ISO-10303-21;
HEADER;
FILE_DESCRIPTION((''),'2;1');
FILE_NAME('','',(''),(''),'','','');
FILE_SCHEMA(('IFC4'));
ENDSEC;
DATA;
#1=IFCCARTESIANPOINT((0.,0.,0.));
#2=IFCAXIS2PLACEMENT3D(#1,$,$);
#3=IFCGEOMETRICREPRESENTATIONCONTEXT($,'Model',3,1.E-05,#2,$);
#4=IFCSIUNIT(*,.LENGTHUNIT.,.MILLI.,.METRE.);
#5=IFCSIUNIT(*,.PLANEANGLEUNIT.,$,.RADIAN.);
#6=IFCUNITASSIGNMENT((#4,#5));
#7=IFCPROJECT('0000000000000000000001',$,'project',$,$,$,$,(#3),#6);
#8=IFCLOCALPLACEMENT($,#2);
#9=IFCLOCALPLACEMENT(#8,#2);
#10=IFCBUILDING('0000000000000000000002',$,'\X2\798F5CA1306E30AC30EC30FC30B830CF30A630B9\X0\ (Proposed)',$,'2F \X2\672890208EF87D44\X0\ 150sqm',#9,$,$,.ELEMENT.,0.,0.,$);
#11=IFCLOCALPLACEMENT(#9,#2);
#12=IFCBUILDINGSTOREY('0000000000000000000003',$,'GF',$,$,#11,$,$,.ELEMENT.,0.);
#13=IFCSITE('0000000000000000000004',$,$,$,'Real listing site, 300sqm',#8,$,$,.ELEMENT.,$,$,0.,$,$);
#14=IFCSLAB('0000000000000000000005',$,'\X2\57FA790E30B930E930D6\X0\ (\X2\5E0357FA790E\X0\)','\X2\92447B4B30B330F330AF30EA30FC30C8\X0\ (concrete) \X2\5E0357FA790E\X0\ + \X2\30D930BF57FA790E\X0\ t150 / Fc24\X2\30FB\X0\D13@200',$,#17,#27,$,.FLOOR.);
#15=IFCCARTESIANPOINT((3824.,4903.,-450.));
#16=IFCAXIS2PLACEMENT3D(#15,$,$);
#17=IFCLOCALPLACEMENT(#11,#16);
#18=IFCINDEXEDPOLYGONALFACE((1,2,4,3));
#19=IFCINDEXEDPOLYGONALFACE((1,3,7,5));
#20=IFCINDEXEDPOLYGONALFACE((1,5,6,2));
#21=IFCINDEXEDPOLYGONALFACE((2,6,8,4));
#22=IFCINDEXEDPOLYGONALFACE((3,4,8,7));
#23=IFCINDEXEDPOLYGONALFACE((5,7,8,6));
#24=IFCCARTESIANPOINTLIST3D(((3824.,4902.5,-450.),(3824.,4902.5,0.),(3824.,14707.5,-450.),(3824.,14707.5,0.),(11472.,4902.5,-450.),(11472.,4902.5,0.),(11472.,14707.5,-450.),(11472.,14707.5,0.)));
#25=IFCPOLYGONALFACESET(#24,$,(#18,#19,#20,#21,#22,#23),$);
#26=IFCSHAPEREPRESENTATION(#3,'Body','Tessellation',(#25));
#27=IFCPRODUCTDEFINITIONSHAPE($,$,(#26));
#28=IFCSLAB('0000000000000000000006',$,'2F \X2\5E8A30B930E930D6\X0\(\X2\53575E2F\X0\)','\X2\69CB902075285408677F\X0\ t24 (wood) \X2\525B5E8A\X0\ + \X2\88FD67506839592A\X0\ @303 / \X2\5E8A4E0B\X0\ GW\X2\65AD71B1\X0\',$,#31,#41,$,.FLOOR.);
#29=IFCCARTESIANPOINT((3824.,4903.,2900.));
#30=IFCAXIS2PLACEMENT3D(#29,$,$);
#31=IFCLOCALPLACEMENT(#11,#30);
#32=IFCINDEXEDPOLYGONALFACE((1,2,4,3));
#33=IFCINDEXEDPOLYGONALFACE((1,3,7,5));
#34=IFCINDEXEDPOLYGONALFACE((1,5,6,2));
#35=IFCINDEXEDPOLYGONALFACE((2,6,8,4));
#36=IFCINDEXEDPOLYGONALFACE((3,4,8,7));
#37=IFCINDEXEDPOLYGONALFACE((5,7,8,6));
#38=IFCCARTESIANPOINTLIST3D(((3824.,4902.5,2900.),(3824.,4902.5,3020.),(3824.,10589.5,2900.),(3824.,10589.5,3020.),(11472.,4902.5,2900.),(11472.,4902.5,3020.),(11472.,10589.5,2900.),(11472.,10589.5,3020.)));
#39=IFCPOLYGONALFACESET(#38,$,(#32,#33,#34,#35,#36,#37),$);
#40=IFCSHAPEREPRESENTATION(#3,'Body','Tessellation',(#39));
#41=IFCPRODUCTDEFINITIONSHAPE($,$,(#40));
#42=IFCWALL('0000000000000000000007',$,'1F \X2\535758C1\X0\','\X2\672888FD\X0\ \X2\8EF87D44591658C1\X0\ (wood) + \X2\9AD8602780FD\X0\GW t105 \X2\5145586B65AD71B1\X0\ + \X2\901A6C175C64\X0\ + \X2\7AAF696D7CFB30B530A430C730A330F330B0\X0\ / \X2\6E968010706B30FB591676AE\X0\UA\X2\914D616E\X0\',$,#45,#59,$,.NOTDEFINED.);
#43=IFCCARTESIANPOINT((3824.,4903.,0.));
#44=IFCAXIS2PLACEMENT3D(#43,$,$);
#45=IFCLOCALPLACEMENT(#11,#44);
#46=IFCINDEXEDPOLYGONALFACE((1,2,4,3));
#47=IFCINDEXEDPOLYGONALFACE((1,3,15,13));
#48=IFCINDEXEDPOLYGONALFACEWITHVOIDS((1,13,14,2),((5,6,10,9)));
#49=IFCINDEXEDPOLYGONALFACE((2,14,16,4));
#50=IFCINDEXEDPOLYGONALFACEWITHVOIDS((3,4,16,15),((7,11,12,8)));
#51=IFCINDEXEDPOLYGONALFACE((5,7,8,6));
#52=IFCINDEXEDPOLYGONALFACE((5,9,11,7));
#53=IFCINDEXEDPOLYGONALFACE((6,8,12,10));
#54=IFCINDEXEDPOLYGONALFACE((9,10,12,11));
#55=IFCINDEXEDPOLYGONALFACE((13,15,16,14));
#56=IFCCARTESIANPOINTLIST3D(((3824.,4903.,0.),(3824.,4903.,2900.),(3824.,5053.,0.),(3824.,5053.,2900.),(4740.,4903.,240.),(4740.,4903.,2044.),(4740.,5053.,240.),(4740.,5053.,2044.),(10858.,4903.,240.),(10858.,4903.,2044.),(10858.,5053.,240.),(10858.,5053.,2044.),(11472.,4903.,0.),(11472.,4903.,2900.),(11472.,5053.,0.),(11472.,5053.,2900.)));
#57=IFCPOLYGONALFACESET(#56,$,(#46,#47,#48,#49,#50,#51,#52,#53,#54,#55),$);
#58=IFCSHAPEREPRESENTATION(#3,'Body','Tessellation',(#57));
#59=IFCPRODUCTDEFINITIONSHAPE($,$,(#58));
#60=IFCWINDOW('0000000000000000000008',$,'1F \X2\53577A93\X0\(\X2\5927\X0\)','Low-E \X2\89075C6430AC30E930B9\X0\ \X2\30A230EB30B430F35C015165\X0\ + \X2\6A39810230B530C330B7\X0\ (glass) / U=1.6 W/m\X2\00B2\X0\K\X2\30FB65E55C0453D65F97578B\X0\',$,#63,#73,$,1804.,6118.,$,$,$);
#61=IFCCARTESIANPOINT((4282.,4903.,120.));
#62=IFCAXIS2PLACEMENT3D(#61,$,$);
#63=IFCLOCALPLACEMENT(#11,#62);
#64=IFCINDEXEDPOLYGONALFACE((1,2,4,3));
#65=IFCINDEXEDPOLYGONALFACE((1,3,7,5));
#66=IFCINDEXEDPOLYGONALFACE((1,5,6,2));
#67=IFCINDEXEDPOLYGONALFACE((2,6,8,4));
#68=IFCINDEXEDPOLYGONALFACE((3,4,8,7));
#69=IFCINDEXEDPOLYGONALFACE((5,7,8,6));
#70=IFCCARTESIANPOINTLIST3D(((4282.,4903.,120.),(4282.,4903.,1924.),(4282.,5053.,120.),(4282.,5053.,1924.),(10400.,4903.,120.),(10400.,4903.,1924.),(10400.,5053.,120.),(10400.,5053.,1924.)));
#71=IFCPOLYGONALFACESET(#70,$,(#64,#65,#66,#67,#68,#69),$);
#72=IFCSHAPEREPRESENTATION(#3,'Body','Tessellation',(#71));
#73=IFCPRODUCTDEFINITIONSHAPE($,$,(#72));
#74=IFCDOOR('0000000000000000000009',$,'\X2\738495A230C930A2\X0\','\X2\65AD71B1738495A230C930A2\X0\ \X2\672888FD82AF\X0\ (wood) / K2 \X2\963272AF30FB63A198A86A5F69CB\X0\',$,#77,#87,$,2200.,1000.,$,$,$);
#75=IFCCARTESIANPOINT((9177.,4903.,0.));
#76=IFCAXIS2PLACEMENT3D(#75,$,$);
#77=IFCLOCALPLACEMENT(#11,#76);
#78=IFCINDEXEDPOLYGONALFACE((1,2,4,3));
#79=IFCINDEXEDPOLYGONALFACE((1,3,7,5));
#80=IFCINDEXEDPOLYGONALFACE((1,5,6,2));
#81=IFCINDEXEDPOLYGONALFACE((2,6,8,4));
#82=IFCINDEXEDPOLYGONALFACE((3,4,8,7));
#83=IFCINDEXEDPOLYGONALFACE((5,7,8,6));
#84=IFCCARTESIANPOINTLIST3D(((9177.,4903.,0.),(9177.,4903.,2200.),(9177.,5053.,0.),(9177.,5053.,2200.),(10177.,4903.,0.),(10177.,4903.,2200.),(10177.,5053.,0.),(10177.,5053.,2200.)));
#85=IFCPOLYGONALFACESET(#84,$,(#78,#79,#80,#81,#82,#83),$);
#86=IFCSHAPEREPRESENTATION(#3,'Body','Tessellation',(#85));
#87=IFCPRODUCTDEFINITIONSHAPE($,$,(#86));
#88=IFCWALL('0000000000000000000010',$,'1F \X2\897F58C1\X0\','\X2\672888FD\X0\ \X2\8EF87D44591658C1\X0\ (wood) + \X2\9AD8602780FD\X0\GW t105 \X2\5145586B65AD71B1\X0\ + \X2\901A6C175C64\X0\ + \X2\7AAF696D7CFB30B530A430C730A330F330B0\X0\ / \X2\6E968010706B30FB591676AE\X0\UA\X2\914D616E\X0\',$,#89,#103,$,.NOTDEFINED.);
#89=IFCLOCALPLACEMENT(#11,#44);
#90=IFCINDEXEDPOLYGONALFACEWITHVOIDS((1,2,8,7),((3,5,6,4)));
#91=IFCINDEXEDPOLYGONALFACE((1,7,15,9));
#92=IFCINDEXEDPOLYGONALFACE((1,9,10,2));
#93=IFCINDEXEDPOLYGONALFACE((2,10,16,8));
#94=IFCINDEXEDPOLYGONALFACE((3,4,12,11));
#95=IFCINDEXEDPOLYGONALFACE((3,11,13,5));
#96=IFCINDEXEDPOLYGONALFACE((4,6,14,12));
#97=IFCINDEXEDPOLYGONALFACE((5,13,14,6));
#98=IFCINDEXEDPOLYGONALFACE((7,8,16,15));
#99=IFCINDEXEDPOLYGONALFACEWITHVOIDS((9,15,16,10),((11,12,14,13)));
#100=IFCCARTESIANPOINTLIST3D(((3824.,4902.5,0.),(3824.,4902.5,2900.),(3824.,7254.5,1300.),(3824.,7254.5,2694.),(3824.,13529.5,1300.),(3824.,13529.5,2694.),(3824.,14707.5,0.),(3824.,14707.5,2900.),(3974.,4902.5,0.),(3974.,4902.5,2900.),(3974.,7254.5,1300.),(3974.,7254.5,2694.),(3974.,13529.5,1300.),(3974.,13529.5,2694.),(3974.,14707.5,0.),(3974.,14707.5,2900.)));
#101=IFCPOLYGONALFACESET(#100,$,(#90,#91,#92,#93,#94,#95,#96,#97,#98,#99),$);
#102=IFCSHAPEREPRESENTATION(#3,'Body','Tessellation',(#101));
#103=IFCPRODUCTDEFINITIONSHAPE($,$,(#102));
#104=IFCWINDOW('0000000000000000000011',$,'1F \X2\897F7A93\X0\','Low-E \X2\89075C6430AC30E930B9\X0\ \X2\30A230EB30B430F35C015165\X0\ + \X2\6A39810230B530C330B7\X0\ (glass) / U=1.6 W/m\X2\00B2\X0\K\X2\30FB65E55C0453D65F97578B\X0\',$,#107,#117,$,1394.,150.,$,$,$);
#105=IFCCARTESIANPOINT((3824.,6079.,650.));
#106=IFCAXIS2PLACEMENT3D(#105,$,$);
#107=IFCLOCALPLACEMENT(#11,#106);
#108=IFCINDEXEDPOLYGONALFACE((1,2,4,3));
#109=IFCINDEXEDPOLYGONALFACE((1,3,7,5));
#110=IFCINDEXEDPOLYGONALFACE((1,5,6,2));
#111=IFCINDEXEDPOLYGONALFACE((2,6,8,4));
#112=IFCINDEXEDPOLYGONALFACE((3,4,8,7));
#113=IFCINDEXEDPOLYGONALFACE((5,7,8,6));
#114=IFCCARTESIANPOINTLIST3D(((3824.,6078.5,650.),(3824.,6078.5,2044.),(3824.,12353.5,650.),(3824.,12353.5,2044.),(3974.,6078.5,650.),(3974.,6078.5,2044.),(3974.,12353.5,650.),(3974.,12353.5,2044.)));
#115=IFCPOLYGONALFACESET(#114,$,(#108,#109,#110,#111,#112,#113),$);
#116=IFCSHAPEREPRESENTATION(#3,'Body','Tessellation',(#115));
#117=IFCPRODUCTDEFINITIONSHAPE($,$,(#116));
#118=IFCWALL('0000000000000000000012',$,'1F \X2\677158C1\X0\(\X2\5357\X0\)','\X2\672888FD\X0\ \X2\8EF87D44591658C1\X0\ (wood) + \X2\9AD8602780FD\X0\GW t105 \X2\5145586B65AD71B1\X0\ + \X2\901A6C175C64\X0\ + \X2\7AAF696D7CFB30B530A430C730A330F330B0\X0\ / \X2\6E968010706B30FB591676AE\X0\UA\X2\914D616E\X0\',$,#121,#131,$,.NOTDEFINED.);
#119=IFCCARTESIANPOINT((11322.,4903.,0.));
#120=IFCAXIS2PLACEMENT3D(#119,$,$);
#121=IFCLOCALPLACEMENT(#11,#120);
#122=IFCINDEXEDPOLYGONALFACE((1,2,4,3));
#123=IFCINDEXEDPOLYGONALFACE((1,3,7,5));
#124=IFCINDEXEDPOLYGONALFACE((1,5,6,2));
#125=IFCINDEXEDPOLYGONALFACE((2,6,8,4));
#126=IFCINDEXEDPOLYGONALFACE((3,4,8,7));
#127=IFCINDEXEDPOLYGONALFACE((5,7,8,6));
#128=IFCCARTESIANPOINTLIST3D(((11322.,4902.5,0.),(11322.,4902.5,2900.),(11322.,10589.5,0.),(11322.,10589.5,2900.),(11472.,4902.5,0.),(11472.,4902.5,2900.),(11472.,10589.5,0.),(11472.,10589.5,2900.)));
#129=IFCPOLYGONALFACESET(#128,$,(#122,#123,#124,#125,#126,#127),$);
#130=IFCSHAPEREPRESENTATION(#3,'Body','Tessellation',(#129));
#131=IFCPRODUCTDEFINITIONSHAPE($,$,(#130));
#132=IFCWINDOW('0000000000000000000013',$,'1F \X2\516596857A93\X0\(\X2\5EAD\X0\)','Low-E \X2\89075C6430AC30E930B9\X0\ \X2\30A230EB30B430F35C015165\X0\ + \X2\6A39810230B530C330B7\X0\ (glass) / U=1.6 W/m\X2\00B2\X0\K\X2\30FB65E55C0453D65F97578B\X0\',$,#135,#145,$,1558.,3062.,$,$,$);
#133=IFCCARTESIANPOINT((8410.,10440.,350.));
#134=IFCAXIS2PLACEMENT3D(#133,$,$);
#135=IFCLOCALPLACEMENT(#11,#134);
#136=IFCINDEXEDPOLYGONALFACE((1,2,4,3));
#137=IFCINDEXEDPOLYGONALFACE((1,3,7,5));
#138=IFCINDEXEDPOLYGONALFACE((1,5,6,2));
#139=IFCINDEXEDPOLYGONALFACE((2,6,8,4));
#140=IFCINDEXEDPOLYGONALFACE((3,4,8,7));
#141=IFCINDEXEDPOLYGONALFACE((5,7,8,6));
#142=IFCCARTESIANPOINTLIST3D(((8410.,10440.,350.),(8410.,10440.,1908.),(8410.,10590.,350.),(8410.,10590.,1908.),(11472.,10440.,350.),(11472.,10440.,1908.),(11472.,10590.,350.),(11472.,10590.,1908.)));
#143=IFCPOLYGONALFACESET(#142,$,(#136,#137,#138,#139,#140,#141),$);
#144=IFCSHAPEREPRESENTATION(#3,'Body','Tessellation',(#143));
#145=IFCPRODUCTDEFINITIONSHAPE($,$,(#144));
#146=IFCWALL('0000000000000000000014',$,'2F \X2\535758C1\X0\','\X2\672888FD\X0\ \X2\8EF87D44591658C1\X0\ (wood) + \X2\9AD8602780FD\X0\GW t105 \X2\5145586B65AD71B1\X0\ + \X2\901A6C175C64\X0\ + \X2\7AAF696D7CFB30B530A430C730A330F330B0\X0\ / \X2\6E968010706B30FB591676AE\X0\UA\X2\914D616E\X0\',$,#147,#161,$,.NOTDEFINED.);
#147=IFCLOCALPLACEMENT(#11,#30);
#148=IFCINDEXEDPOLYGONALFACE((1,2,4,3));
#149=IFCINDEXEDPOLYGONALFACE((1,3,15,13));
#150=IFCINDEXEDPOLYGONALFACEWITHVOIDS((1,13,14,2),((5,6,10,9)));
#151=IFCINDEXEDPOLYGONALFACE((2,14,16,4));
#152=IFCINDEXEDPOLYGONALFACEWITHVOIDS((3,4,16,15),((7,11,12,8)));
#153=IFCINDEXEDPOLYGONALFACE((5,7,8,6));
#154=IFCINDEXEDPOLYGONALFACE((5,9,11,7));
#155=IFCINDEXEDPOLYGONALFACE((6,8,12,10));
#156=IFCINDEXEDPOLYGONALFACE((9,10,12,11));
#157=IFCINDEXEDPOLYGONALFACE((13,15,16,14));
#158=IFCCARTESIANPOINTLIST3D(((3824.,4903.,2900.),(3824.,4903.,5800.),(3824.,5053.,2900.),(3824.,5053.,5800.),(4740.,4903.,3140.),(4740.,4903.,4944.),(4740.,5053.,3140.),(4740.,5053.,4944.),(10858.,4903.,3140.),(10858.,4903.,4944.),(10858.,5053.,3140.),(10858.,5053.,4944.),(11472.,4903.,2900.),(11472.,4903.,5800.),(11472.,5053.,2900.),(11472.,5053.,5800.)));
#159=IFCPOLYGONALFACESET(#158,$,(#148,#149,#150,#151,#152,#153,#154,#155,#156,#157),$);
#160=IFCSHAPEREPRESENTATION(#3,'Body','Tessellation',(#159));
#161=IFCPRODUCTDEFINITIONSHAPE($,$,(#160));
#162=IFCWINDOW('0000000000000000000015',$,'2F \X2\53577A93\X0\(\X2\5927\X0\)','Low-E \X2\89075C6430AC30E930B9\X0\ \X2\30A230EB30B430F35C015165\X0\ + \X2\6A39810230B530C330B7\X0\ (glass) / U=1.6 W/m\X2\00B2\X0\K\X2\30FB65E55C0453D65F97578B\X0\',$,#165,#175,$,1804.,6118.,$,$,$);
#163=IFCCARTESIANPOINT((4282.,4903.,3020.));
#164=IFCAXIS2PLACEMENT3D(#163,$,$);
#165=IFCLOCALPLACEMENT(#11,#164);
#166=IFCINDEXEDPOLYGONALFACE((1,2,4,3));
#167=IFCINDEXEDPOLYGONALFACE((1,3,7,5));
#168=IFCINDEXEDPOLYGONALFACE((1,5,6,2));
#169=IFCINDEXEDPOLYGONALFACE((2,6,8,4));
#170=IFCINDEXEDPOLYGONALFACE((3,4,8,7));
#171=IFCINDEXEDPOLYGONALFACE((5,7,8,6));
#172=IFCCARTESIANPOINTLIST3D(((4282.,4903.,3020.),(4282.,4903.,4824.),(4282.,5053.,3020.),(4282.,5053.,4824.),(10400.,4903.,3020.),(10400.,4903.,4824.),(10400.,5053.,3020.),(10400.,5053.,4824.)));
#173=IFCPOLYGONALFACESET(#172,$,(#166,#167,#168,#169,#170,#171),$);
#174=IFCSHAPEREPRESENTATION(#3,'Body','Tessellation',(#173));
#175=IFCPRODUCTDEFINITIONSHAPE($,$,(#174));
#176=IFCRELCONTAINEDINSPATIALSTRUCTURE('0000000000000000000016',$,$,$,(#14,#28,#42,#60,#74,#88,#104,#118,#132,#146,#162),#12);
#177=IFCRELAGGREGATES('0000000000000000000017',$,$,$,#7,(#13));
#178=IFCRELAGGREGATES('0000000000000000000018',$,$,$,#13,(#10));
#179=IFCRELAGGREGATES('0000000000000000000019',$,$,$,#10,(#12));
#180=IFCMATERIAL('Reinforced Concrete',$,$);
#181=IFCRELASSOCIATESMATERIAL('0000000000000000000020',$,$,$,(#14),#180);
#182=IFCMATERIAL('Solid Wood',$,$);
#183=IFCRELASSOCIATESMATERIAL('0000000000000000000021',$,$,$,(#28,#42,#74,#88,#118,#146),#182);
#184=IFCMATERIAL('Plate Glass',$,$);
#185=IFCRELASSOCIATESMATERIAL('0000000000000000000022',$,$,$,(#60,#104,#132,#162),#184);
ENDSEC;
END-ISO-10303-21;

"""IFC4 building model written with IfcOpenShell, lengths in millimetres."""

from ifc_helpers import new_model, si_unit, frame, frame_2d, origin, place, context, project, spatial, rectangle, extrude, material, element, fill, save


model = new_model("IFC4")

# Units and contexts
model_context = context("Model", 3, precision=1e-05, world=origin())
ifc_project = project(units=[si_unit("LENGTHUNIT", "METRE", prefix="MILLI"), si_unit("PLANEANGLEUNIT", "RADIAN")], contexts=[model_context])

# Site, building, storey
site_placement = place(None, origin())
site = spatial("IfcSite", under=ifc_project, at=site_placement, ObjectType="Real listing site, 300sqm", CompositionType="ELEMENT", RefElevation=0.0)
building_placement = place(site_placement, origin())
building = spatial("IfcBuilding", under=site, at=building_placement, Name="福岡のガレージハウス (Proposed)", ObjectType="2F 木造軸組 150sqm", CompositionType="ELEMENT", ElevationOfRefHeight=0.0, ElevationOfTerrain=0.0)
storey_placement = place(building_placement, origin())
storey = spatial("IfcBuildingStorey", under=building, at=storey_placement, Name="GF", CompositionType="ELEMENT", Elevation=0.0)

# Slabs
ifc_material_1 = material(Name="Reinforced Concrete")
slab_1_placement = place(storey_placement, frame((3824.0, 4903.0, -450.0)))
element("IfcSlab", 1, at=slab_1_placement, inside=storey, material=ifc_material_1, Name="基礎スラブ (布基礎)", Description="鉄筋コンクリート (concrete) 布基礎 + ベタ基礎 t150 / Fc24・D13@200", PredefinedType="FLOOR", context=model_context, shape_type="SweptSolid", body=[
    extrude(rectangle(XDim=7648.0, YDim=9805.0, at=frame_2d((3824.0, 4902.0))), frame((3824.0, 4903.0, -450.0)), (0.0, 0.0, 1.0), 450.0),
])
ifc_material_2 = material(Name="Solid Wood")
slab_2_placement = place(storey_placement, frame((3824.0, 4903.0, 2900.0)))
element("IfcSlab", 2, at=slab_2_placement, inside=storey, material=ifc_material_2, Name="2F 床スラブ(南帯)", Description="構造用合板 t24 (wood) 剛床 + 製材根太 @303 / 床下 GW断熱", PredefinedType="FLOOR", context=model_context, shape_type="SweptSolid", body=[
    extrude(rectangle(XDim=7648.0, YDim=5687.0, at=frame_2d((3824.0, 2843.0))), frame((3824.0, 4903.0, 2900.0)), (0.0, 0.0, 1.0), 120.0),
])

# Wall, openings, window, door
wall_1_placement = place(storey_placement, frame((3824.0, 4903.0, 0.0)))
wall_1 = element("IfcWall", 3, at=wall_1_placement, inside=storey, material=ifc_material_2, Name="1F 南壁", Description="木製 軸組外壁 (wood) + 高性能GW t105 充填断熱 + 通気層 + 窯業系サイディング / 準耐火・外皮UA配慮", PredefinedType="NOTDEFINED", context=model_context, shape_type="SweptSolid", body=[
    extrude(rectangle(XDim=7648.0, YDim=150.0, at=frame_2d((3824.0, 75.0))), frame((3824.0, 4903.0, 0.0)), (0.0, 0.0, 1.0), 2900.0),
])
opening_1_placement = place(storey_placement, frame((4282.0, 4903.0, 120.0)))
opening_1 = element("IfcOpeningElement", 4, at=opening_1_placement, cuts=wall_1, PredefinedType="NOTDEFINED", context=model_context, shape_type="SweptSolid", body=[
    extrude(rectangle(XDim=6118.0, YDim=150.0, at=frame_2d((3059.0, 75.0))), frame((4282.0, 4903.0, 120.0)), (0.0, 0.0, 1.0), 1804.0),
])
opening_2_placement = place(storey_placement, frame((9177.0, 4903.0, 0.0)))
opening_2 = element("IfcOpeningElement", 5, at=opening_2_placement, cuts=wall_1, PredefinedType="NOTDEFINED", context=model_context, shape_type="SweptSolid", body=[
    extrude(rectangle(XDim=1000.0, YDim=150.0, at=frame_2d((500.0, 75.0))), frame((9177.0, 4903.0, 0.0)), (0.0, 0.0, 1.0), 2200.0),
])
ifc_material_3 = material(Name="Plate Glass")
window_1_placement = place(storey_placement, frame((4282.0, 4903.0, 120.0)))
window_1 = element("IfcWindow", 6, at=window_1_placement, inside=storey, material=ifc_material_3, Name="1F 南窓(大)", Description="Low-E 複層ガラス アルゴン封入 + 樹脂サッシ (glass) / U=1.6 W/m²K・日射取得型", OverallHeight=1804.0, OverallWidth=6118.0, context=model_context, shape_type="SweptSolid", body=[
    extrude(rectangle(XDim=6118.0, YDim=150.0, at=frame_2d((3059.0, 75.0))), frame((4282.0, 4903.0, 120.0)), (0.0, 0.0, 1.0), 1804.0),
])
fill(opening_1, window_1)
door_placement = place(storey_placement, frame((9177.0, 4903.0, 0.0)))
door = element("IfcDoor", 7, at=door_placement, inside=storey, material=ifc_material_2, Name="玄関ドア", Description="断熱玄関ドア 木製芯 (wood) / K2 防犯・採風機構", OverallHeight=2200.0, OverallWidth=1000.0, context=model_context, shape_type="SweptSolid", body=[
    extrude(rectangle(XDim=1000.0, YDim=150.0, at=frame_2d((500.0, 75.0))), frame((9177.0, 4903.0, 0.0)), (0.0, 0.0, 1.0), 2200.0),
])
fill(opening_2, door)

# Walls, openings, windows
wall_2_placement = place(storey_placement, frame((3824.0, 4903.0, 0.0)))
wall_2 = element("IfcWall", 8, at=wall_2_placement, inside=storey, material=ifc_material_2, Name="1F 西壁", Description="木製 軸組外壁 (wood) + 高性能GW t105 充填断熱 + 通気層 + 窯業系サイディング / 準耐火・外皮UA配慮", PredefinedType="NOTDEFINED", context=model_context, shape_type="SweptSolid", body=[
    extrude(rectangle(XDim=150.0, YDim=9805.0, at=frame_2d((75.0, 4902.0))), frame((3824.0, 4903.0, 0.0)), (0.0, 0.0, 1.0), 2900.0),
])
opening_3_placement = place(storey_placement, frame((3824.0, 6079.0, 650.0)))
opening_3 = element("IfcOpeningElement", 9, at=opening_3_placement, cuts=wall_2, PredefinedType="NOTDEFINED", context=model_context, shape_type="SweptSolid", body=[
    extrude(rectangle(XDim=150.0, YDim=6275.0, at=frame_2d((75.0, 3137.0))), frame((3824.0, 6079.0, 650.0)), (0.0, 0.0, 1.0), 1394.0),
])
window_2_placement = place(storey_placement, frame((3824.0, 6079.0, 650.0)))
window_2 = element("IfcWindow", 10, at=window_2_placement, inside=storey, material=ifc_material_3, Name="1F 西窓", Description="Low-E 複層ガラス アルゴン封入 + 樹脂サッシ (glass) / U=1.6 W/m²K・日射取得型", OverallHeight=1394.0, OverallWidth=150.0, context=model_context, shape_type="SweptSolid", body=[
    extrude(rectangle(XDim=150.0, YDim=6275.0, at=frame_2d((75.0, 3137.0))), frame((3824.0, 6079.0, 650.0)), (0.0, 0.0, 1.0), 1394.0),
])
fill(opening_3, window_2)
wall_3_placement = place(storey_placement, frame((11322.0, 4903.0, 0.0)))
wall_3 = element("IfcWall", 11, at=wall_3_placement, inside=storey, material=ifc_material_2, Name="1F 東壁(南)", Description="木製 軸組外壁 (wood) + 高性能GW t105 充填断熱 + 通気層 + 窯業系サイディング / 準耐火・外皮UA配慮", PredefinedType="NOTDEFINED", context=model_context, shape_type="SweptSolid", body=[
    extrude(rectangle(XDim=150.0, YDim=5687.0, at=frame_2d((75.0, 2843.0))), frame((11322.0, 4903.0, 0.0)), (0.0, 0.0, 1.0), 2900.0),
])
opening_4_placement = place(storey_placement, frame((8410.0, 10440.0, 350.0)))
opening_4 = element("IfcOpeningElement", 12, at=opening_4_placement, cuts=wall_3, PredefinedType="NOTDEFINED", context=model_context, shape_type="SweptSolid", body=[
    extrude(rectangle(XDim=3062.0, YDim=150.0, at=frame_2d((1531.0, 75.0))), frame((8410.0, 10440.0, 350.0)), (0.0, 0.0, 1.0), 1558.0),
])
window_3_placement = place(storey_placement, frame((8410.0, 10440.0, 350.0)))
window_3 = element("IfcWindow", 13, at=window_3_placement, inside=storey, material=ifc_material_3, Name="1F 入隅窓(庭)", Description="Low-E 複層ガラス アルゴン封入 + 樹脂サッシ (glass) / U=1.6 W/m²K・日射取得型", OverallHeight=1558.0, OverallWidth=3062.0, context=model_context, shape_type="SweptSolid", body=[
    extrude(rectangle(XDim=3062.0, YDim=150.0, at=frame_2d((1531.0, 75.0))), frame((8410.0, 10440.0, 350.0)), (0.0, 0.0, 1.0), 1558.0),
])
fill(opening_4, window_3)

# Wall, opening, window
wall_4_placement = place(storey_placement, frame((3824.0, 4903.0, 2900.0)))
wall_4 = element("IfcWall", 14, at=wall_4_placement, inside=storey, material=ifc_material_2, Name="2F 南壁", Description="木製 軸組外壁 (wood) + 高性能GW t105 充填断熱 + 通気層 + 窯業系サイディング / 準耐火・外皮UA配慮", PredefinedType="NOTDEFINED", context=model_context, shape_type="SweptSolid", body=[
    extrude(rectangle(XDim=7648.0, YDim=150.0, at=frame_2d((3824.0, 75.0))), frame((3824.0, 4903.0, 2900.0)), (0.0, 0.0, 1.0), 2900.0),
])
opening_5_placement = place(storey_placement, frame((4282.0, 4903.0, 3020.0)))
opening_5 = element("IfcOpeningElement", 15, at=opening_5_placement, cuts=wall_4, PredefinedType="NOTDEFINED", context=model_context, shape_type="SweptSolid", body=[
    extrude(rectangle(XDim=6118.0, YDim=150.0, at=frame_2d((3059.0, 75.0))), frame((4282.0, 4903.0, 3020.0)), (0.0, 0.0, 1.0), 1804.0),
])
window_4_placement = place(storey_placement, frame((4282.0, 4903.0, 3020.0)))
window_4 = element("IfcWindow", 16, at=window_4_placement, inside=storey, material=ifc_material_3, Name="2F 南窓(大)", Description="Low-E 複層ガラス アルゴン封入 + 樹脂サッシ (glass) / U=1.6 W/m²K・日射取得型", OverallHeight=1804.0, OverallWidth=6118.0, context=model_context, shape_type="SweptSolid", body=[
    extrude(rectangle(XDim=6118.0, YDim=150.0, at=frame_2d((3059.0, 75.0))), frame((4282.0, 4903.0, 3020.0)), (0.0, 0.0, 1.0), 1804.0),
])
fill(opening_5, window_4)

save(model, "model.ifc")
